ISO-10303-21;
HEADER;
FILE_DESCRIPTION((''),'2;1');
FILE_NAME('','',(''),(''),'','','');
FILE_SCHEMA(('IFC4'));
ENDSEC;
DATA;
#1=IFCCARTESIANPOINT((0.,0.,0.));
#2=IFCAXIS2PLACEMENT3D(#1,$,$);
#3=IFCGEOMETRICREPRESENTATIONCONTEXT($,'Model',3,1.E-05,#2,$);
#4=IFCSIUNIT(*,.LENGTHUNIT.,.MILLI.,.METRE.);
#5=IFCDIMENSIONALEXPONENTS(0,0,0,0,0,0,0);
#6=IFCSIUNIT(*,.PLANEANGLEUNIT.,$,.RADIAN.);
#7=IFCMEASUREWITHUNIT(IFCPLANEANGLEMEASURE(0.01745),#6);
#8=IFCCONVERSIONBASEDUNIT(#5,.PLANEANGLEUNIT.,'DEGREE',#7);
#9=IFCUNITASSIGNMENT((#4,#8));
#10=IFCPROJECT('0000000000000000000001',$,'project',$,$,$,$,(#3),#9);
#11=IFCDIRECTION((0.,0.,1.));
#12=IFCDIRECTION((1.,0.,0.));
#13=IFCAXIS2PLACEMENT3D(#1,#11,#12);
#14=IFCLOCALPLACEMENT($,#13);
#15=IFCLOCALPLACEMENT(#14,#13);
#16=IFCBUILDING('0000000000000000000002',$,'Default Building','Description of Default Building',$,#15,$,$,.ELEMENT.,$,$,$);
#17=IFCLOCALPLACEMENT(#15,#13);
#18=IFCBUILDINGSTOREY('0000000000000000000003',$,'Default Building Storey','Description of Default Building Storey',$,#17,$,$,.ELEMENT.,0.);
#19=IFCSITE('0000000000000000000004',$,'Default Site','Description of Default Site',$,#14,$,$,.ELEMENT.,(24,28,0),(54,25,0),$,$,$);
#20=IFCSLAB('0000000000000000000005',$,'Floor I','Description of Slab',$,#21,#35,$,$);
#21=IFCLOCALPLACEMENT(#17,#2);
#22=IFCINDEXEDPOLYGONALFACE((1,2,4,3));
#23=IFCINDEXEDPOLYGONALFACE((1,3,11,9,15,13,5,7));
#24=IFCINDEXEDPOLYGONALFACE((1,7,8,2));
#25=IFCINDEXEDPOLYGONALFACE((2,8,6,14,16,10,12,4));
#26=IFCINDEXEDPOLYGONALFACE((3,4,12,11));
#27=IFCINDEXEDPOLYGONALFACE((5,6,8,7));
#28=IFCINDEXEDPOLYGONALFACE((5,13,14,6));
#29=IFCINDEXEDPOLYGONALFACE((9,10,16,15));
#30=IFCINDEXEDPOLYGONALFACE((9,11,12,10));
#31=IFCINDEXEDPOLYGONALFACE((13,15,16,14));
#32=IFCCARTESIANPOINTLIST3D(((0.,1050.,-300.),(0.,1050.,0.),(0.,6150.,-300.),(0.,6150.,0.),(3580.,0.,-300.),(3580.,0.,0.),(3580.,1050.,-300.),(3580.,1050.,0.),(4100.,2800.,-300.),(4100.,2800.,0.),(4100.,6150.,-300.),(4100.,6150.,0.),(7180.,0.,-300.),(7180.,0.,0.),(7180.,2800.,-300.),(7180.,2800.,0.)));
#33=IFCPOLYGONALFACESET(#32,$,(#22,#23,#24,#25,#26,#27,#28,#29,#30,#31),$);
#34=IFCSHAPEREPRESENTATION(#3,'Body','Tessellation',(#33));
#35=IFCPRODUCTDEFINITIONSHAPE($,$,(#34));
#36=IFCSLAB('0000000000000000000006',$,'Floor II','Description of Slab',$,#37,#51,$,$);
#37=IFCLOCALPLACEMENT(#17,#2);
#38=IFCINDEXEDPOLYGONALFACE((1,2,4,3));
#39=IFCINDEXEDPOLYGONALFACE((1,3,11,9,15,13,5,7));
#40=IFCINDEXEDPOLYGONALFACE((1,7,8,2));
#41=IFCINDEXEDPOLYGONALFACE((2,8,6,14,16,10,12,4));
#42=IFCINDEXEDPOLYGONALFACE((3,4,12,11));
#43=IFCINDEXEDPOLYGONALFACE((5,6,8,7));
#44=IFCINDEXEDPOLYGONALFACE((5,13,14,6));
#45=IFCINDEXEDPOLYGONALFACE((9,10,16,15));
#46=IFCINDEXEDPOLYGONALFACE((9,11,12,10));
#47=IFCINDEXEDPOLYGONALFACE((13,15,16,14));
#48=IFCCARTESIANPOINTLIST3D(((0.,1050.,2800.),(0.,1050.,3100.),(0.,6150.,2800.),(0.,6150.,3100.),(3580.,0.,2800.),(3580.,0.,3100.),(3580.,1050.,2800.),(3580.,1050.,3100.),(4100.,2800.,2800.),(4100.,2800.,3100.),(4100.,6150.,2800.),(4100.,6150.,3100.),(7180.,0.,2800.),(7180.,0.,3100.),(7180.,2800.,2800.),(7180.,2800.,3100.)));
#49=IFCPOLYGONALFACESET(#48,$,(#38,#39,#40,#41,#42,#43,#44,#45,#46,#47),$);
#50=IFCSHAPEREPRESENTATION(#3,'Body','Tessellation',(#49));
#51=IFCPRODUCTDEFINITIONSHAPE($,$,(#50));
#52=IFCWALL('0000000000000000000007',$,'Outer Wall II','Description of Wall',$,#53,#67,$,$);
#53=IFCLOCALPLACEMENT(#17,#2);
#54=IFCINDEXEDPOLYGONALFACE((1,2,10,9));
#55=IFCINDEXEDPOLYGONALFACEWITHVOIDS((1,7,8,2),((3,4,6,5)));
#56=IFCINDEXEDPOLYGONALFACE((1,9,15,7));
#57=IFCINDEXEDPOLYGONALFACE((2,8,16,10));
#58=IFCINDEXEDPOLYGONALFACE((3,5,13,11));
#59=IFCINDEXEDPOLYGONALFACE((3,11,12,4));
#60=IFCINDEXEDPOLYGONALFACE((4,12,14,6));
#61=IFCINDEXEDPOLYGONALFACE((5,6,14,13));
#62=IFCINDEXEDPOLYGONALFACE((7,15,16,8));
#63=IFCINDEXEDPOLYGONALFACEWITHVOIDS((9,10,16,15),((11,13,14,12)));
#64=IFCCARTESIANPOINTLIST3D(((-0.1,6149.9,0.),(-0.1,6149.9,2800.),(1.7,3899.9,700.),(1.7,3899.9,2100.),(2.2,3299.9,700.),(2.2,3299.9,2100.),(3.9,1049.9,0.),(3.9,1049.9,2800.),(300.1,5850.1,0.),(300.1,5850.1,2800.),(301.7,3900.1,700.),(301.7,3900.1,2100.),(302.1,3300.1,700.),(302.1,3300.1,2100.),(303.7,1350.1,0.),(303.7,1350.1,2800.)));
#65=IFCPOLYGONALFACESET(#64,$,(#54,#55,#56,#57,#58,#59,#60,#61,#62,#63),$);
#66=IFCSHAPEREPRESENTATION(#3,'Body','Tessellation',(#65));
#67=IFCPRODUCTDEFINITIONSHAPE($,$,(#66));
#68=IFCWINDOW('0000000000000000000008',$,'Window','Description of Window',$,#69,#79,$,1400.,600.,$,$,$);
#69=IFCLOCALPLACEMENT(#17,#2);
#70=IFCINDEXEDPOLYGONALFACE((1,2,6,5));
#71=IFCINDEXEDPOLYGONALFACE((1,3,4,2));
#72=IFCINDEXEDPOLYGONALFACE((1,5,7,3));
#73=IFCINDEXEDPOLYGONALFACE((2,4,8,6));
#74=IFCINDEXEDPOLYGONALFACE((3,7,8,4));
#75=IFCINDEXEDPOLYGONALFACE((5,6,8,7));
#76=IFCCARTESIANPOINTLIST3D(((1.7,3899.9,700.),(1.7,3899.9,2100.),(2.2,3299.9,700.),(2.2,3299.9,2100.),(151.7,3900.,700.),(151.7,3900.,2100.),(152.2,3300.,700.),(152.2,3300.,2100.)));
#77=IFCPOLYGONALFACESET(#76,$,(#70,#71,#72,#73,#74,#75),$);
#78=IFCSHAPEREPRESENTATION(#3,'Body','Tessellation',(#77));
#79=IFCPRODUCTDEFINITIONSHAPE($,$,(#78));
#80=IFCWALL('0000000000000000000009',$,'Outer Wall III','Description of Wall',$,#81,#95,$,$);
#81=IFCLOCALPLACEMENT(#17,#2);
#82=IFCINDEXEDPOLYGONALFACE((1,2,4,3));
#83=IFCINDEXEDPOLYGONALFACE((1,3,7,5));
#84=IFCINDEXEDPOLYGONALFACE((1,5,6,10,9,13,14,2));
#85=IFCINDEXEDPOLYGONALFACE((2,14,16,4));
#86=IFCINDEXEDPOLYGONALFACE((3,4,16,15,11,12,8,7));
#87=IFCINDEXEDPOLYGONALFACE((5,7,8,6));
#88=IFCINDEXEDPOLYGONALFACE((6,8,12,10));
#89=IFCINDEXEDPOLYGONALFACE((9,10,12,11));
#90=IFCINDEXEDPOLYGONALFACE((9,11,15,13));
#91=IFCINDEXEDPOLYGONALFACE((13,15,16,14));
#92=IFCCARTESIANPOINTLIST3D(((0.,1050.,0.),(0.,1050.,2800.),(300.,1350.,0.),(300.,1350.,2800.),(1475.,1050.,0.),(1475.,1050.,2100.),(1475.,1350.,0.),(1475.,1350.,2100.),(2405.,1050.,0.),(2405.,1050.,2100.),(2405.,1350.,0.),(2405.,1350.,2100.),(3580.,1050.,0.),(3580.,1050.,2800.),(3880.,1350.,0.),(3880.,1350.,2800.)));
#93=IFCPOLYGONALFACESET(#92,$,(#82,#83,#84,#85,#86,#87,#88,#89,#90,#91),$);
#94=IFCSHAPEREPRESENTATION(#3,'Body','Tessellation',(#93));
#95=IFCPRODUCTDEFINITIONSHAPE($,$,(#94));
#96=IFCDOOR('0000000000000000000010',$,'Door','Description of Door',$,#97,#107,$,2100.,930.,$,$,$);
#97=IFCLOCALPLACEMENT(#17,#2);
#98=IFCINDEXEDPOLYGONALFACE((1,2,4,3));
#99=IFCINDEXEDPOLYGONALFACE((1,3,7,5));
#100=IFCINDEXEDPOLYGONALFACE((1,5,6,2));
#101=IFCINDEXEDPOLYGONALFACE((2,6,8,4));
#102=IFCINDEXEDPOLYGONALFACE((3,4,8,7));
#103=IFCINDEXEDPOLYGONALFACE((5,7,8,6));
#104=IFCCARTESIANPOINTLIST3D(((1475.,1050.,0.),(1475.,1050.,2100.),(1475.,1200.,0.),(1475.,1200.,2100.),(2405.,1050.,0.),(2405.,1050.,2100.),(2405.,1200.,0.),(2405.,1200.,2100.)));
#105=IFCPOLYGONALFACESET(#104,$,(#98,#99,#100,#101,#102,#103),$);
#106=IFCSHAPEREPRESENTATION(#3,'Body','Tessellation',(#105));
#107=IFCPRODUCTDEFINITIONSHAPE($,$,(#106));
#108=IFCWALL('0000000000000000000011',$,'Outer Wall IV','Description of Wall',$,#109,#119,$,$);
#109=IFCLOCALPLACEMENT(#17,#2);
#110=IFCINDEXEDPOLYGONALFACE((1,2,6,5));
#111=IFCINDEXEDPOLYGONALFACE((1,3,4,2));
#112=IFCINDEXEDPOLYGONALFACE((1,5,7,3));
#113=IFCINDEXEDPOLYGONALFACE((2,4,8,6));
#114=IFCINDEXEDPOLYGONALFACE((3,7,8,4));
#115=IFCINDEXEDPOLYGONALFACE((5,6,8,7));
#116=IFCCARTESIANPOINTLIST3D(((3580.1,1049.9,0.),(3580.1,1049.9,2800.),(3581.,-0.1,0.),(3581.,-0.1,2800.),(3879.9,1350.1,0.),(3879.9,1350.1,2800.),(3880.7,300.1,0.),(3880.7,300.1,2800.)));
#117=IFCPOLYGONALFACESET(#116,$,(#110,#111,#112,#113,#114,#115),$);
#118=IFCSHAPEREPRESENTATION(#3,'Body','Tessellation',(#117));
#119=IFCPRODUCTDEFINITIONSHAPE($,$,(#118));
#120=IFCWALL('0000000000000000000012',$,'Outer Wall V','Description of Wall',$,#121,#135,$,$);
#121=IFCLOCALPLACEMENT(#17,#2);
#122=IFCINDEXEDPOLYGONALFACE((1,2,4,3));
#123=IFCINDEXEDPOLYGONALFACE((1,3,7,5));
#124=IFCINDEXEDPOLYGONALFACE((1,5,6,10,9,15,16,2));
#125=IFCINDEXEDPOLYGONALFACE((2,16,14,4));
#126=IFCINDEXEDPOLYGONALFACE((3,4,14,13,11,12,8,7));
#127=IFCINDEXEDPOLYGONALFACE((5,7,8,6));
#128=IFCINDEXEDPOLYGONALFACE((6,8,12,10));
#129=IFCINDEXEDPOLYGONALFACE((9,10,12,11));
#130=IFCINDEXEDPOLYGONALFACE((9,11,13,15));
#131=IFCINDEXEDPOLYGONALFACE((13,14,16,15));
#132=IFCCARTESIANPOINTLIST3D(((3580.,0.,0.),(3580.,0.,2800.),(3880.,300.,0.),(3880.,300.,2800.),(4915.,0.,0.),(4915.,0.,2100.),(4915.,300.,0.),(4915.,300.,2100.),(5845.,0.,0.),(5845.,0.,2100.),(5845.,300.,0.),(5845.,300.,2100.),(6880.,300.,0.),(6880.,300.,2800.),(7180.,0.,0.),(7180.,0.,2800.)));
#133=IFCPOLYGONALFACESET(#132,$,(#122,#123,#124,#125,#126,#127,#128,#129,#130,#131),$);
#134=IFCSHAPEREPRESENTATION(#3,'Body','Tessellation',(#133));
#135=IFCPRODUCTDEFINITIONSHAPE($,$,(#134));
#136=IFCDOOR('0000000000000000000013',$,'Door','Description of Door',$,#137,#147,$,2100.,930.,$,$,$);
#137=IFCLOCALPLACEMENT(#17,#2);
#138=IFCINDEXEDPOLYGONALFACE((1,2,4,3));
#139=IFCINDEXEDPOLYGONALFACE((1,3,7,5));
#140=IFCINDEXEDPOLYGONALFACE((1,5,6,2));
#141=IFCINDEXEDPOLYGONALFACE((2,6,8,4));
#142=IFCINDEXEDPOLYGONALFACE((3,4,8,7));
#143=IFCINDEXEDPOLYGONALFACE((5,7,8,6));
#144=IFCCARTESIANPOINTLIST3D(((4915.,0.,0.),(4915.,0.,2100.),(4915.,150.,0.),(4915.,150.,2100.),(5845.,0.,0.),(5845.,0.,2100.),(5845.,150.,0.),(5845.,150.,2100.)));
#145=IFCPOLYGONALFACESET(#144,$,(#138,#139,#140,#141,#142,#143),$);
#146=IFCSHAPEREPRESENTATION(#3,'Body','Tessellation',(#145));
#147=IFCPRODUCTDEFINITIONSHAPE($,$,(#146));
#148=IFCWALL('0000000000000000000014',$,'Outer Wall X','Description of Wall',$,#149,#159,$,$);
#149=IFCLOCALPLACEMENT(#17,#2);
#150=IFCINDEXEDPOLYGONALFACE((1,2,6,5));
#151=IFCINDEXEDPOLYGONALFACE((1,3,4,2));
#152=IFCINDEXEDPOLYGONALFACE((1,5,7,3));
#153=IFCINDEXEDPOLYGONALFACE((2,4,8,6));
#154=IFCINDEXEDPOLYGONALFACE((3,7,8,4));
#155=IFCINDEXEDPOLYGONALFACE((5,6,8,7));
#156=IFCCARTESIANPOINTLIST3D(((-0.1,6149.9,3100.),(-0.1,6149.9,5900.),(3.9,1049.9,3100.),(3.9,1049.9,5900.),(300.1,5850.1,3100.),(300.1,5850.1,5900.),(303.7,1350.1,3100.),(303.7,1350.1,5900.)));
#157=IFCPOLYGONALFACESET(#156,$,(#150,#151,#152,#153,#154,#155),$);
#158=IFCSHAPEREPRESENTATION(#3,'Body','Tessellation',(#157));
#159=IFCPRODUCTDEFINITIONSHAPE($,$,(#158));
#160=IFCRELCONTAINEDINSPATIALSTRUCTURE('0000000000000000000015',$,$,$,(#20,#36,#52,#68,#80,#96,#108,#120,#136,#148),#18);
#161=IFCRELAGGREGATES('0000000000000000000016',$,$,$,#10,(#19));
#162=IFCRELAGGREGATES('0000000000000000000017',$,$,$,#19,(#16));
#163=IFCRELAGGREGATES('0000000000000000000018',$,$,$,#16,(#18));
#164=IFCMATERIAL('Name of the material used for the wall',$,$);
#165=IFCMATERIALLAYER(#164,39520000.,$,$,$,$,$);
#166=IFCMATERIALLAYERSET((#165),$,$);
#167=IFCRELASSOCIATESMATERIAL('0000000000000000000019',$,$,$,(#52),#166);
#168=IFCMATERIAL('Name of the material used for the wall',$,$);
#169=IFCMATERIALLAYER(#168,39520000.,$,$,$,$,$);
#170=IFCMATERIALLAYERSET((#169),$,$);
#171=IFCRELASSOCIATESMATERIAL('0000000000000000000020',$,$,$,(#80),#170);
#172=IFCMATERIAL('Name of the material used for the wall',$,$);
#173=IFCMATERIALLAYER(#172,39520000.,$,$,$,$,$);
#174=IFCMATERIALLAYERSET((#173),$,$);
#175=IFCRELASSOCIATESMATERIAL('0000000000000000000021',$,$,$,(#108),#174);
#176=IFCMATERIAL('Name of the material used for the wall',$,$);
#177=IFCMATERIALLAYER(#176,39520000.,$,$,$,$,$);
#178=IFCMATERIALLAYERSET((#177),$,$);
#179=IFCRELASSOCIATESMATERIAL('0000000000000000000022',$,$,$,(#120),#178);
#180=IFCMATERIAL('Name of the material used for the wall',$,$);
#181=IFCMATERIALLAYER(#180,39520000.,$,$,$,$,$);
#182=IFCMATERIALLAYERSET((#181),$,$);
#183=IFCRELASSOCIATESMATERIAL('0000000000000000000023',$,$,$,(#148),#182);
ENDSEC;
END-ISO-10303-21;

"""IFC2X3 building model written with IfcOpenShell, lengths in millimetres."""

from ifc_helpers import new_model, entity, si_unit, converted_unit, frame, origin, origin_with_axes, place, context, project, spatial, polyline, outline, extrude, material, layer, layer_set, layer_usage, element, fill, save


model = new_model("IFC2X3")

# Units and contexts
model_context = context("Model", 3, precision=1e-05, world=origin())
ifc_project = project(units=[si_unit("LENGTHUNIT", "METRE", prefix="MILLI"), converted_unit("PLANEANGLEUNIT", "DEGREE", entity("IfcPlaneAngleMeasure", 0.01745), si_unit("PLANEANGLEUNIT", "RADIAN"), dimensions=[0, 0, 0, 0, 0, 0, 0])], contexts=[model_context])

# Site, building, storey
site_placement = place(None, origin_with_axes())
site = spatial("IfcSite", under=ifc_project, at=site_placement, Name="Default Site", Description="Description of Default Site", CompositionType="ELEMENT", RefLatitude=(24, 28, 0), RefLongitude=(54, 25, 0))
building_placement = place(site_placement, origin_with_axes())
building = spatial("IfcBuilding", under=site, at=building_placement, Name="Default Building", Description="Description of Default Building", CompositionType="ELEMENT")
storey_placement = place(building_placement, origin_with_axes())
storey = spatial("IfcBuildingStorey", under=building, at=storey_placement, Name="Default Building Storey", Description="Description of Default Building Storey", CompositionType="ELEMENT", Elevation=0.0)

# Slabs
for number, where, z_axis, x_axis, name in (
    (1, (0.0, 0.0, -300.0), (0.0, 0.0, 1.0), (1.0, 0.0, 0.0), "Floor I"),
    (2, (0.0, 0.0, 2800.0), (0.0, 0.0, 1.0), (1.0, 0.0, 0.0), "Floor II"),
):
    element("IfcSlab", number, at=place(storey_placement, frame(where, z_axis=z_axis, x_axis=x_axis)), inside=storey, Name=name, Description="Description of Slab", context=model_context, shape_type="SweptSolid", body=[
        extrude(outline(polyline([(0.0, 1050.0), (0.0, 6150.0), (4100.0, 6150.0), (4100.0, 2800.0), (7180.0, 2800.0), (7180.0, 0.0), (3580.0, 0.0), (3580.0, 1050.0), (0.0, 1050.0)])), origin_with_axes(), (0.0, 0.0, 1.0), 300.0),
    ])

# Wall, opening, window
ifc_material_1 = material(Name="Name of the material used for the wall")
ifc_layer_1 = layer(ifc_material_1, 39520000.0)
ifc_layer_set_1 = layer_set([ifc_layer_1])
ifc_layer_usage_1 = layer_usage(ifc_layer_set_1, "AXIS2", "POSITIVE", -19760000.0)
wall_1_placement = place(storey_placement, frame((150.0, 6000.0, 0.0), z_axis=(0.0, 0.0, 1.0), x_axis=(0.000796, -1.0, 0.0)))
wall_1 = element("IfcWall", 3, at=wall_1_placement, inside=storey, material=ifc_layer_usage_1, Name="Outer Wall II", Description="Description of Wall", context=model_context, shape_type="SweptSolid", body=[
    extrude(outline(polyline([(-150.0, -150.0), (150.0, 150.0), (4650.0, 150.0), (4950.0, -150.0), (-150.0, -150.0)])), origin_with_axes(), (0.0, 0.0, 1.0), 2800.0),
])
opening_1_placement = place(wall_1_placement, frame((2100.0, -150.0, 700.0), z_axis=(0.0, 0.0, 1.0), x_axis=(1.0, 0.0, 0.0)))
opening_1 = element("IfcOpeningElement", 4, at=opening_1_placement, cuts=wall_1, context=model_context, shape_type="SweptSolid", body=[
    extrude(outline(polyline([(0.0, 0.0), (0.0, 300.0), (600.0, 300.0), (600.0, 0.0), (0.0, 0.0)])), origin_with_axes(), (0.0, 0.0, 1.0), 1400.0),
])
window_1_placement = place(opening_1_placement, origin_with_axes())
window_1 = element("IfcWindow", 5, at=window_1_placement, inside=storey, Name="Window", Description="Description of Window", OverallHeight=1400.0, OverallWidth=600.0, context=model_context, shape_type="SweptSolid", body=[
    extrude(outline(polyline([(0.0, 0.0), (0.0, 150.0), (600.0, 150.0), (600.0, 0.0), (0.0, 0.0)])), origin_with_axes(), (0.0, 0.0, 1.0), 1400.0),
])
fill(opening_1, window_1)

# Wall, opening, door
ifc_material_2 = material(Name="Name of the material used for the wall")
ifc_layer_2 = layer(ifc_material_2, 39520000.0)
ifc_layer_set_2 = layer_set([ifc_layer_2])
ifc_layer_usage_2 = layer_usage(ifc_layer_set_2, "AXIS2", "POSITIVE", -19760000.0)
wall_2_placement = place(storey_placement, frame((150.0, 1200.0, 0.0), z_axis=(0.0, 0.0, 1.0), x_axis=(1.0, 0.0, 0.0)))
wall_2 = element("IfcWall", 6, at=wall_2_placement, inside=storey, material=ifc_layer_usage_2, Name="Outer Wall III", Description="Description of Wall", context=model_context, shape_type="SweptSolid", body=[
    extrude(outline(polyline([(-150.0, -150.0), (150.0, 150.0), (3730.0, 150.0), (3430.0, -150.0), (-150.0, -150.0)])), origin_with_axes(), (0.0, 0.0, 1.0), 2800.0),
])
opening_2_placement = place(wall_2_placement, frame((1325.0, -150.0, 0.0), z_axis=(0.0, 0.0, 1.0), x_axis=(1.0, 0.0, 0.0)))
opening_2 = element("IfcOpeningElement", 7, at=opening_2_placement, cuts=wall_2, context=model_context, shape_type="SweptSolid", body=[
    extrude(outline(polyline([(0.0, 0.0), (0.0, 300.0), (930.0, 300.0), (930.0, 0.0), (0.0, 0.0)])), origin_with_axes(), (0.0, 0.0, 1.0), 2100.0),
])
door_1_placement = place(opening_2_placement, origin_with_axes())
door_1 = element("IfcDoor", 8, at=door_1_placement, inside=storey, Name="Door", Description="Description of Door", OverallHeight=2100.0, OverallWidth=930.0, context=model_context, shape_type="SweptSolid", body=[
    extrude(outline(polyline([(0.0, 0.0), (0.0, 150.0), (930.0, 150.0), (930.0, 0.0), (0.0, 0.0)])), origin_with_axes(), (0.0, 0.0, 1.0), 2100.0),
])
fill(opening_2, door_1)

# Wall
ifc_material_3 = material(Name="Name of the material used for the wall")
ifc_layer_3 = layer(ifc_material_3, 39520000.0)
ifc_layer_set_3 = layer_set([ifc_layer_3])
ifc_layer_usage_3 = layer_usage(ifc_layer_set_3, "AXIS2", "POSITIVE", -19760000.0)
wall_3_placement = place(storey_placement, frame((3730.0, 1200.0, 0.0), z_axis=(0.0, 0.0, 1.0), x_axis=(0.000796, -1.0, 0.0)))
element("IfcWall", 9, at=wall_3_placement, inside=storey, material=ifc_layer_usage_3, Name="Outer Wall IV", Description="Description of Wall", context=model_context, shape_type="SweptSolid", body=[
    extrude(outline(polyline([(150.0, -150.0), (-150.0, 150.0), (900.0, 150.0), (1200.0, -150.0), (150.0, -150.0)])), origin_with_axes(), (0.0, 0.0, 1.0), 2800.0),
])

# Wall, opening, door
ifc_material_4 = material(Name="Name of the material used for the wall")
ifc_layer_4 = layer(ifc_material_4, 39520000.0)
ifc_layer_set_4 = layer_set([ifc_layer_4])
ifc_layer_usage_4 = layer_usage(ifc_layer_set_4, "AXIS2", "POSITIVE", -19760000.0)
wall_4_placement = place(storey_placement, frame((3730.0, 150.0, 0.0), z_axis=(0.0, 0.0, 1.0), x_axis=(1.0, 0.0, 0.0)))
wall_4 = element("IfcWall", 10, at=wall_4_placement, inside=storey, material=ifc_layer_usage_4, Name="Outer Wall V", Description="Description of Wall", context=model_context, shape_type="SweptSolid", body=[
    extrude(outline(polyline([(-150.0, -150.0), (150.0, 150.0), (3150.0, 150.0), (3450.0, -150.0), (-150.0, -150.0)])), origin_with_axes(), (0.0, 0.0, 1.0), 2800.0),
])
opening_3_placement = place(wall_4_placement, frame((1185.0, -150.0, 0.0), z_axis=(0.0, 0.0, 1.0), x_axis=(1.0, 0.0, 0.0)))
opening_3 = element("IfcOpeningElement", 11, at=opening_3_placement, cuts=wall_4, context=model_context, shape_type="SweptSolid", body=[
    extrude(outline(polyline([(0.0, 0.0), (0.0, 300.0), (930.0, 300.0), (930.0, 0.0), (0.0, 0.0)])), origin_with_axes(), (0.0, 0.0, 1.0), 2100.0),
])
door_2_placement = place(opening_3_placement, origin_with_axes())
door_2 = element("IfcDoor", 12, at=door_2_placement, inside=storey, Name="Door", Description="Description of Door", OverallHeight=2100.0, OverallWidth=930.0, context=model_context, shape_type="SweptSolid", body=[
    extrude(outline(polyline([(0.0, 0.0), (0.0, 150.0), (930.0, 150.0), (930.0, 0.0), (0.0, 0.0)])), origin_with_axes(), (0.0, 0.0, 1.0), 2100.0),
])
fill(opening_3, door_2)

# Wall
ifc_material_5 = material(Name="Name of the material used for the wall")
ifc_layer_5 = layer(ifc_material_5, 39520000.0)
ifc_layer_set_5 = layer_set([ifc_layer_5])
ifc_layer_usage_5 = layer_usage(ifc_layer_set_5, "AXIS2", "POSITIVE", -19760000.0)
wall_5_placement = place(storey_placement, frame((150.0, 6000.0, 3100.0), z_axis=(0.0, 0.0, 1.0), x_axis=(0.000796, -1.0, 0.0)))
element("IfcWall", 13, at=wall_5_placement, inside=storey, material=ifc_layer_usage_5, Name="Outer Wall X", Description="Description of Wall", context=model_context, shape_type="SweptSolid", body=[
    extrude(outline(polyline([(-150.0, -150.0), (150.0, 150.0), (4650.0, 150.0), (4950.0, -150.0), (-150.0, -150.0)])), origin_with_axes(), (0.0, 0.0, 1.0), 2800.0),
])

save(model, "model.ifc")
